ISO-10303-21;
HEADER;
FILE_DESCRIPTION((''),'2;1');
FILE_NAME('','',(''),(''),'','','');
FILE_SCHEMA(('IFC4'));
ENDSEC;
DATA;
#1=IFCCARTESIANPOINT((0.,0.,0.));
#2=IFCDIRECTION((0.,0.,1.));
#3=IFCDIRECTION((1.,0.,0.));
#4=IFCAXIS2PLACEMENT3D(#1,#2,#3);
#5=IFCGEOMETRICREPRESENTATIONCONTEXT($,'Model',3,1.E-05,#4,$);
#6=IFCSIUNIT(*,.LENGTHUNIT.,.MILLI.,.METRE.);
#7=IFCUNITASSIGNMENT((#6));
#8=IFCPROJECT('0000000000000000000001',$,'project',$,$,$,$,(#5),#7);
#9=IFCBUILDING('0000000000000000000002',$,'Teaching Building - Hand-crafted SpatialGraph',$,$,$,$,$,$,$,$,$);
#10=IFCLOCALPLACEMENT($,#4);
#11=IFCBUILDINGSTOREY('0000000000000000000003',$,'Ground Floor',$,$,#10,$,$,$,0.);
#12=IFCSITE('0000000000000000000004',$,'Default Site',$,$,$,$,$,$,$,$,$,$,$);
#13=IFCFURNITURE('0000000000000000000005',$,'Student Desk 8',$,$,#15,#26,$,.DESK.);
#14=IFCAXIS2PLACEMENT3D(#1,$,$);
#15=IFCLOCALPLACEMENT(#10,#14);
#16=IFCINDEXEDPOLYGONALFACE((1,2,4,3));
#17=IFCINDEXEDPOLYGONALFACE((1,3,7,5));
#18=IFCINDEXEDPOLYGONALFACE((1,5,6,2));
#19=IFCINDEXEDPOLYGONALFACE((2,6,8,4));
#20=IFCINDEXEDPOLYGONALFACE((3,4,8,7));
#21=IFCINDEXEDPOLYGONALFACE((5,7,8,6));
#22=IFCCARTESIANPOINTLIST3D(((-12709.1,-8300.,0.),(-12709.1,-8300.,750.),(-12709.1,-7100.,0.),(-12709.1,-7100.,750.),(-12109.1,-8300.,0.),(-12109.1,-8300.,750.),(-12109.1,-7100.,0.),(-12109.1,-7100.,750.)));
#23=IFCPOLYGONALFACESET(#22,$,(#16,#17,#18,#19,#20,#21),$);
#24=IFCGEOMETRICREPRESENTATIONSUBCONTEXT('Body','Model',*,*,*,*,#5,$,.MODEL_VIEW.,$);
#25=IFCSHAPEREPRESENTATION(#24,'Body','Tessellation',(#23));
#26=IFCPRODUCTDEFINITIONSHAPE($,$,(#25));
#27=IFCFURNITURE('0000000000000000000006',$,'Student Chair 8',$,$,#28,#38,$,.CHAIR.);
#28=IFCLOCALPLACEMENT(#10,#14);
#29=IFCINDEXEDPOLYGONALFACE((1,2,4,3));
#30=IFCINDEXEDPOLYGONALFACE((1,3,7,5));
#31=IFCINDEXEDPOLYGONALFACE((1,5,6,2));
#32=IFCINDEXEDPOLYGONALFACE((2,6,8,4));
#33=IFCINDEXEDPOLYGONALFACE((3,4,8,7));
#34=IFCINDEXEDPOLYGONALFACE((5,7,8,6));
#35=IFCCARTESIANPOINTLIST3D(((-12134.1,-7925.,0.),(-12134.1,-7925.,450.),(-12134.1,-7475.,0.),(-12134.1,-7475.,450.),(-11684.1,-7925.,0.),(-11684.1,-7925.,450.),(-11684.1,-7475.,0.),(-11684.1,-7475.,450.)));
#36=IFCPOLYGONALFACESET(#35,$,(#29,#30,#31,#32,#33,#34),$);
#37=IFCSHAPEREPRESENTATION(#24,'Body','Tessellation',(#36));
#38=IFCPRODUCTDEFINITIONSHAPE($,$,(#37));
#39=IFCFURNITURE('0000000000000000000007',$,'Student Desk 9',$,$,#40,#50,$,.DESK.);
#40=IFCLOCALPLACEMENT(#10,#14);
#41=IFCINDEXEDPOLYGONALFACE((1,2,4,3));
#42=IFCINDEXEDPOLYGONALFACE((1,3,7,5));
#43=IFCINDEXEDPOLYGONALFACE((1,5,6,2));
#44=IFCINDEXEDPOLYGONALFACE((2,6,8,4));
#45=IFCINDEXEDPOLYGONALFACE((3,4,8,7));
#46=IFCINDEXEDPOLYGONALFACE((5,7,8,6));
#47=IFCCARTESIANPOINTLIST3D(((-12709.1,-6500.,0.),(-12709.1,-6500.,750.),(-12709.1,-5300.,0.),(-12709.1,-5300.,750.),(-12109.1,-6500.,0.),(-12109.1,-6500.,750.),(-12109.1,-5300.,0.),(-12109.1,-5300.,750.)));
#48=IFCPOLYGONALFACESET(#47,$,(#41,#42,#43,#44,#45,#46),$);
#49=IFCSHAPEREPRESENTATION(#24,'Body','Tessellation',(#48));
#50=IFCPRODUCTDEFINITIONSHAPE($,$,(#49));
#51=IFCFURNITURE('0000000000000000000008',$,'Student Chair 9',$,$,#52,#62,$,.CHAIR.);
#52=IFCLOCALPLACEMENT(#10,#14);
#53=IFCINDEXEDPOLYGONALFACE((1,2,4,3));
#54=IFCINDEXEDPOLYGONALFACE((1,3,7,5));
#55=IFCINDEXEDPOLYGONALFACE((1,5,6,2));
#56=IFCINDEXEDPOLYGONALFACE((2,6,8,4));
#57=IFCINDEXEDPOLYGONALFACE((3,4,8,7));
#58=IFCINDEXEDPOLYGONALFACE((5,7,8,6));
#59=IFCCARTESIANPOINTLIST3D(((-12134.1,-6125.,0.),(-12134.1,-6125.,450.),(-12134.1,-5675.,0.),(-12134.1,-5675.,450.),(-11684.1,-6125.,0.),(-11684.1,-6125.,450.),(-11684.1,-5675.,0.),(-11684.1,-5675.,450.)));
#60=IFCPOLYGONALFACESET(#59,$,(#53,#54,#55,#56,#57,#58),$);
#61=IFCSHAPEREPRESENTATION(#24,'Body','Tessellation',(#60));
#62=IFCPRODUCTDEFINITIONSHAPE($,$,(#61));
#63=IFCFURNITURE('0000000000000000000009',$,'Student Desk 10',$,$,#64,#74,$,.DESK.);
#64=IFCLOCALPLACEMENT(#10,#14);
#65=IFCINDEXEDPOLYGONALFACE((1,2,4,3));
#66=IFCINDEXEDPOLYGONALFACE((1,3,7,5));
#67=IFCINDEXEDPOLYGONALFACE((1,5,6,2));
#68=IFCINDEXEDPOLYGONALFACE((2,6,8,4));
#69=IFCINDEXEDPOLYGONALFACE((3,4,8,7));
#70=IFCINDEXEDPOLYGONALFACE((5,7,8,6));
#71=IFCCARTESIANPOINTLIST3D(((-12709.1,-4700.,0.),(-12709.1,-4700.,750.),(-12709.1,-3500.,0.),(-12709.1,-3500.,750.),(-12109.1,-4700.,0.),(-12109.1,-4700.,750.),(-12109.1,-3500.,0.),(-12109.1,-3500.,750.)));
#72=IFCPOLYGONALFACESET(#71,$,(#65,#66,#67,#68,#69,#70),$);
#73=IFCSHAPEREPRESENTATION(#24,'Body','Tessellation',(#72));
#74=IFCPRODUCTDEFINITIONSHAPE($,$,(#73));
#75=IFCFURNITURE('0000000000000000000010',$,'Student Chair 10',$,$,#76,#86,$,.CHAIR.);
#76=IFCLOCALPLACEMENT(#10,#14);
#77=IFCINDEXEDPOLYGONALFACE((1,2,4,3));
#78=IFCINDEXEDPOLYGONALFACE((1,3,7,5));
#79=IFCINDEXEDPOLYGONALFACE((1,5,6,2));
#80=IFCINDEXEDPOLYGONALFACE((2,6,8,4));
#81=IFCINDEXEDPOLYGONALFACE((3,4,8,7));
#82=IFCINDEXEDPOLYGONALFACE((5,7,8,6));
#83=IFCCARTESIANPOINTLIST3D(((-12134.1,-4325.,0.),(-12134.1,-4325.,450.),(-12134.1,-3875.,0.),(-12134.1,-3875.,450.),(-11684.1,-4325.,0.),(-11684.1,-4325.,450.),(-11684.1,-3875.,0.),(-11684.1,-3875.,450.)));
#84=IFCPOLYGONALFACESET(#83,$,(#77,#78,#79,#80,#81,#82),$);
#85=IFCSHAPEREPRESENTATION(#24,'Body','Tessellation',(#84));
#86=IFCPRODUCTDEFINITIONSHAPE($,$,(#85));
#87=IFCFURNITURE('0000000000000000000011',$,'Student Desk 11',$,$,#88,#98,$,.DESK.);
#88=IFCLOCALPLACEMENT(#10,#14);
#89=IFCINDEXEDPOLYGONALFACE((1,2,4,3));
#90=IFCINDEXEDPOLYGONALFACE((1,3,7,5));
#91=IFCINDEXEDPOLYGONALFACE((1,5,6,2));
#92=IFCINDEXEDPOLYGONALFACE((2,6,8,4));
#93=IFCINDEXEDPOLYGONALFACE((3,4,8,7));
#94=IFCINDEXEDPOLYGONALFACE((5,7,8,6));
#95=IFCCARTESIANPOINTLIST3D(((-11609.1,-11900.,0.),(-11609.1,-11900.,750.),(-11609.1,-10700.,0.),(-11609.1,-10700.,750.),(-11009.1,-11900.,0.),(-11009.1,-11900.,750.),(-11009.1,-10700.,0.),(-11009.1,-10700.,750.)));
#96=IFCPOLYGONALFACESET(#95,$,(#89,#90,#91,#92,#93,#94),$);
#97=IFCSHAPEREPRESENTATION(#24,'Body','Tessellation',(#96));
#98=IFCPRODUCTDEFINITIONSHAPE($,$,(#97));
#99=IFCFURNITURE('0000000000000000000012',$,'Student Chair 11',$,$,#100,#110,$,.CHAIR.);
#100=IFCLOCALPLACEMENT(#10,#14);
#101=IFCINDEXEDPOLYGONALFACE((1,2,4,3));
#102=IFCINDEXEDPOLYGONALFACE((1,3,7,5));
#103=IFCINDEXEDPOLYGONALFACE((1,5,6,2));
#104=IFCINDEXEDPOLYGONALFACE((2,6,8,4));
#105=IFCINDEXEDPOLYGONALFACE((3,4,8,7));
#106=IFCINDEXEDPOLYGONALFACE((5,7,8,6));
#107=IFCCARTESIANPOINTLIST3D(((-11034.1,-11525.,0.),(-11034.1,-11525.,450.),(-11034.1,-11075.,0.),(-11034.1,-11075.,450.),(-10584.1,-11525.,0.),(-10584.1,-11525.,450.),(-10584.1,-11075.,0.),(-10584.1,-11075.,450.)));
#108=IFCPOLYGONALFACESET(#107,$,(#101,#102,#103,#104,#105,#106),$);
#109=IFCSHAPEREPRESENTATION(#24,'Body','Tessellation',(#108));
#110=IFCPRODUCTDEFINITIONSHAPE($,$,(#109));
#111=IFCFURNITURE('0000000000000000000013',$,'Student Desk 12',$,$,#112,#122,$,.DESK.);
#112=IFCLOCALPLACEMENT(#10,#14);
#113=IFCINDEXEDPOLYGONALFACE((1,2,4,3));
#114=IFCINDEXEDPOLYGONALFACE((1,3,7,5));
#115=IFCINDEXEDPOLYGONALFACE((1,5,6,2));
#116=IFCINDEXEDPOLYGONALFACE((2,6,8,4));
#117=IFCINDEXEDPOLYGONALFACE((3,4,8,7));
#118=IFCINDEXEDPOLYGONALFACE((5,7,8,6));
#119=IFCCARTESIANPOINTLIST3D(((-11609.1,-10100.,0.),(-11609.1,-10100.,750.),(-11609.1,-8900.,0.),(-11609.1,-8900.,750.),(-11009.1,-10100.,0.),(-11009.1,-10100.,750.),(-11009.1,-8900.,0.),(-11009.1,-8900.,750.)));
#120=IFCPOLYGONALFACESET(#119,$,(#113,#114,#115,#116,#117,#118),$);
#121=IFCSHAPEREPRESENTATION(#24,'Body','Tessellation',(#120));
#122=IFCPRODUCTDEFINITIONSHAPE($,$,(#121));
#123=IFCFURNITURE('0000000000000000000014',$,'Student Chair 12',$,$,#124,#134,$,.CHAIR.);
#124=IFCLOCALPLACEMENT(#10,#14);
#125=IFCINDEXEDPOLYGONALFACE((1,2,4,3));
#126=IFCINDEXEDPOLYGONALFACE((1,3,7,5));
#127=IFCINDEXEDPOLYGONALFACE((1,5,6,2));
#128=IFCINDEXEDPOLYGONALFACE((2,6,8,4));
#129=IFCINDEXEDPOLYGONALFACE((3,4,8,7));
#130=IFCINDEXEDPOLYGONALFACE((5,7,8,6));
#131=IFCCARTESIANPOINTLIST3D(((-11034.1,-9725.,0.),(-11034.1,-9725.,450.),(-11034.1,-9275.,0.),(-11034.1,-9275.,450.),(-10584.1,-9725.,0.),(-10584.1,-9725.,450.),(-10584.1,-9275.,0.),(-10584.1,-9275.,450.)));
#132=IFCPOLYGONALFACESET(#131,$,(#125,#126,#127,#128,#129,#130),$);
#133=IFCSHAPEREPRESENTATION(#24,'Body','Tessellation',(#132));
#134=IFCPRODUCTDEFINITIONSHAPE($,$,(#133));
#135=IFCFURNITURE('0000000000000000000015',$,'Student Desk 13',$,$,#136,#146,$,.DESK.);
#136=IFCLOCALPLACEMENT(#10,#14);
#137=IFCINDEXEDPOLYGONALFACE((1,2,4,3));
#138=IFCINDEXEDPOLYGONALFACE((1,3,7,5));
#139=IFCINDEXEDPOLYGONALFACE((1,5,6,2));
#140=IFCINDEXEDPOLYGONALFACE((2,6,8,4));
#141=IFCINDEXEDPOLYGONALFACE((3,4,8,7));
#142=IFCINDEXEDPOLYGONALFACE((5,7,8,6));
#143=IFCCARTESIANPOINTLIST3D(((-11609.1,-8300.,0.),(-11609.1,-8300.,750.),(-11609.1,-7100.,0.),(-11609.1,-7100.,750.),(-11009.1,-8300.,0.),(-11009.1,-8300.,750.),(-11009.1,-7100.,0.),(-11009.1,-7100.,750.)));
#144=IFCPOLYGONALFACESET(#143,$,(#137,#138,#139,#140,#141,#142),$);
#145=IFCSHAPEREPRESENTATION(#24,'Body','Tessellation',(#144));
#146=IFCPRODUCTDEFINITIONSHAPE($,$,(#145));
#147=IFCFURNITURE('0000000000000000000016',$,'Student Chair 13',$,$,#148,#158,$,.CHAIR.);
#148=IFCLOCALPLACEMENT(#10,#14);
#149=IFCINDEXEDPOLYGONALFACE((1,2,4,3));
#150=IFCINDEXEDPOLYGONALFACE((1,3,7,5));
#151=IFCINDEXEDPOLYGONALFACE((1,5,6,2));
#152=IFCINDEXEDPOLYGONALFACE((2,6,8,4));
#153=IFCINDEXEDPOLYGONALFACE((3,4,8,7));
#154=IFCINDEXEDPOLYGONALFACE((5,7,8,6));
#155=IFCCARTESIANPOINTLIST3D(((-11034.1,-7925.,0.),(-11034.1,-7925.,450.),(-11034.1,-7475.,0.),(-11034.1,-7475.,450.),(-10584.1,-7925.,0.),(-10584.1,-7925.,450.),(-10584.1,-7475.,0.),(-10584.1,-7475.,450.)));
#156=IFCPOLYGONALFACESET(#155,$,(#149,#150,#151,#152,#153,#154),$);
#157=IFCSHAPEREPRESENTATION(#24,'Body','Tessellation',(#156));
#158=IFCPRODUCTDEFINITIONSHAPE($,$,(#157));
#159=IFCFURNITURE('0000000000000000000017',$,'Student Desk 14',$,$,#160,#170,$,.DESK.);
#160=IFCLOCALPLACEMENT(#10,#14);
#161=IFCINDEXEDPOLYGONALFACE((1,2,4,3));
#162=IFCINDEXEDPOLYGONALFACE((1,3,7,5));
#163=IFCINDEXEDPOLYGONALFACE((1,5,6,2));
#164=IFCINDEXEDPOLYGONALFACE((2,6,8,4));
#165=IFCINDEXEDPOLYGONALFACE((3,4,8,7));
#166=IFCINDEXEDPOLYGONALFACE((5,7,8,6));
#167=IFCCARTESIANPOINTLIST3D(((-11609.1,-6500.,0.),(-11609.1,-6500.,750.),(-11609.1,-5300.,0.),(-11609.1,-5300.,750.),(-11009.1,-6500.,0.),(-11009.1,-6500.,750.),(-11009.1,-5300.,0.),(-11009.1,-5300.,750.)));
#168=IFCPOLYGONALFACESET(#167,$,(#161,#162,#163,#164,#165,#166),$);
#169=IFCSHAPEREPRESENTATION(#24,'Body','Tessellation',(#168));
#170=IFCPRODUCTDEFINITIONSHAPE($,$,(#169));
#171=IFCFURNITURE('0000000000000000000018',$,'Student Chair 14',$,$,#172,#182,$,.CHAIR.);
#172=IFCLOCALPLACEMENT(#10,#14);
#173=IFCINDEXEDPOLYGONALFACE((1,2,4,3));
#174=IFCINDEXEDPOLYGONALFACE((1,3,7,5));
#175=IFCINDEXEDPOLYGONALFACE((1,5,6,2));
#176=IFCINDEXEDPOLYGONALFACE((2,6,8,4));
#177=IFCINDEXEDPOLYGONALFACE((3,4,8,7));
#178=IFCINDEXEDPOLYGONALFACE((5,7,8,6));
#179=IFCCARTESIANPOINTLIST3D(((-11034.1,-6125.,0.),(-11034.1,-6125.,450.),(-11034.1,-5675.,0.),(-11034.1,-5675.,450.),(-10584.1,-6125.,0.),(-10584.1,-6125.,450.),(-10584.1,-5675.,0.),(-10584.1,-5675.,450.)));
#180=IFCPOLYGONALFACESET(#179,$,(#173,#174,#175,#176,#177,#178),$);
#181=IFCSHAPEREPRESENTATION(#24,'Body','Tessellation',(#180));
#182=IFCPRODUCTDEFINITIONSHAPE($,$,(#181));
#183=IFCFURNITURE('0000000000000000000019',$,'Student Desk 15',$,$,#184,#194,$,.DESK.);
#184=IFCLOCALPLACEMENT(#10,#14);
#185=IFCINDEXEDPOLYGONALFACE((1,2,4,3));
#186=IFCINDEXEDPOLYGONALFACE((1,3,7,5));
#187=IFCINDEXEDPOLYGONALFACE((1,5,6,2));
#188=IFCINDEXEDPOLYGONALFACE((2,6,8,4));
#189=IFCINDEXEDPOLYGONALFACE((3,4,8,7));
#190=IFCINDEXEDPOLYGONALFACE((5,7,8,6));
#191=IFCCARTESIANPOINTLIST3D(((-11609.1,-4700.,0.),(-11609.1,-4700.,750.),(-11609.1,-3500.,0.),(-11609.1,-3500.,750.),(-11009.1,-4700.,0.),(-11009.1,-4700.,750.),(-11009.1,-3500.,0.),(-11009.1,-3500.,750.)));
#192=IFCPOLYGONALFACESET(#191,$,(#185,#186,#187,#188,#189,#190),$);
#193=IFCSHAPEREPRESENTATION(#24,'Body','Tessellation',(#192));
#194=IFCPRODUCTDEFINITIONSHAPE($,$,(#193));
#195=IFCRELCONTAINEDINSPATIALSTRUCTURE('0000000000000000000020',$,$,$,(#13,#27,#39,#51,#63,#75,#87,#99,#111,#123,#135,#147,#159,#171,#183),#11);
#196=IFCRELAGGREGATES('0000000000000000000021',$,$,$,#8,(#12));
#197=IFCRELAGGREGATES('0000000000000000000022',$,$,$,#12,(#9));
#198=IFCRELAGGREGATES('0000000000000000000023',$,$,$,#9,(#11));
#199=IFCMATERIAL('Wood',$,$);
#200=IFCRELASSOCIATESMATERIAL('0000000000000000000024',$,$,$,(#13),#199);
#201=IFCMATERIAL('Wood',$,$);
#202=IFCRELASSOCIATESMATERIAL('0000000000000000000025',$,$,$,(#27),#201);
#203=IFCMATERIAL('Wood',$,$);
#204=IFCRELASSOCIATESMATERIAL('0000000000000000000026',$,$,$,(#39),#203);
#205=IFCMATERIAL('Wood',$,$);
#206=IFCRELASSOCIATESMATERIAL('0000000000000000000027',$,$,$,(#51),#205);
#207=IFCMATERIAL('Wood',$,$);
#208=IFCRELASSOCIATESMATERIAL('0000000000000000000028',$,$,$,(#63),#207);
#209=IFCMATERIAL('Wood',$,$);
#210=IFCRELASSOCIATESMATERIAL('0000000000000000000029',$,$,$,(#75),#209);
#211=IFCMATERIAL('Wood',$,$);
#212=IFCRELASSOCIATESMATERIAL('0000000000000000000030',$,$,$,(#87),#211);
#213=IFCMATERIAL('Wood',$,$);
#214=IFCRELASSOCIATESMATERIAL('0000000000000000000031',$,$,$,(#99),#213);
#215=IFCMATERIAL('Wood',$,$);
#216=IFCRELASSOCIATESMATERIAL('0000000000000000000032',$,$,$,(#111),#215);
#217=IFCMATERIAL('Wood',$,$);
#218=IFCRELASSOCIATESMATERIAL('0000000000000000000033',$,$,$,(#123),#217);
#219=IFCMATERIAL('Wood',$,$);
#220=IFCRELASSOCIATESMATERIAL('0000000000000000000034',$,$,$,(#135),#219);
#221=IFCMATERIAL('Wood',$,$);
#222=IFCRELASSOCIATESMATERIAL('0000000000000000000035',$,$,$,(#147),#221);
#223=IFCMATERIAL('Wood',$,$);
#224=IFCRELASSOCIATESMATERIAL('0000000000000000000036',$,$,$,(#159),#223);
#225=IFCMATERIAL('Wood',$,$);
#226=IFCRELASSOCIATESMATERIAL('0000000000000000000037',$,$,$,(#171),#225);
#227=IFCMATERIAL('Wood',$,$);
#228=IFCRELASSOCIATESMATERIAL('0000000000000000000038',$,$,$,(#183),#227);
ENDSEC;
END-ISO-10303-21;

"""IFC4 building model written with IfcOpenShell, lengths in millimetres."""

from ifc_helpers import new_model, si_unit, frame, origin_with_axes, origin_2d, place, context, subcontext, project, spatial, rectangle, extrude, material, element, save


model = new_model("IFC4")

# Units and contexts
model_context = context("Model", 3, precision=1e-05, world=origin_with_axes())
body_context = subcontext(model_context, "Body", "Model", "MODEL_VIEW")
ifc_project = project(units=[si_unit("LENGTHUNIT", "METRE", prefix="MILLI")], contexts=[model_context])

# Site, building, storey
site = spatial("IfcSite", under=ifc_project, Name="Default Site")
building = spatial("IfcBuilding", under=site, Name="Teaching Building - Hand-crafted SpatialGraph")
storey_placement = place(None, origin_with_axes())
storey = spatial("IfcBuildingStorey", under=building, at=storey_placement, Name="Ground Floor", Elevation=0.0)

# Furniture
ifc_material_1 = material(Name="Wood")
furniture_1_placement = place(storey_placement, frame((-12409.1, -7700.0, 0.0), z_axis=(0.0, 0.0, 1.0), x_axis=(0.0, 1.0, 0.0)))
element("IfcFurniture", 1, at=furniture_1_placement, inside=storey, material=ifc_material_1, Name="Student Desk 8", PredefinedType="DESK", context=body_context, shape_type="SweptSolid", body=[
    extrude(rectangle(XDim=1200.0, YDim=600.0, at=origin_2d()), origin_with_axes(), (0.0, 0.0, 1.0), 750.0),
])
ifc_material_2 = material(Name="Wood")
furniture_2_placement = place(storey_placement, frame((-11909.1, -7700.0, 0.0), z_axis=(0.0, 0.0, 1.0), x_axis=(1.0, 0.0, 0.0)))
element("IfcFurniture", 2, at=furniture_2_placement, inside=storey, material=ifc_material_2, Name="Student Chair 8", PredefinedType="CHAIR", context=body_context, shape_type="SweptSolid", body=[
    extrude(rectangle(XDim=450.0, YDim=450.0, at=origin_2d()), origin_with_axes(), (0.0, 0.0, 1.0), 450.0),
])
ifc_material_3 = material(Name="Wood")
furniture_3_placement = place(storey_placement, frame((-12409.1, -5900.0, 0.0), z_axis=(0.0, 0.0, 1.0), x_axis=(0.0, 1.0, 0.0)))
element("IfcFurniture", 3, at=furniture_3_placement, inside=storey, material=ifc_material_3, Name="Student Desk 9", PredefinedType="DESK", context=body_context, shape_type="SweptSolid", body=[
    extrude(rectangle(XDim=1200.0, YDim=600.0, at=origin_2d()), origin_with_axes(), (0.0, 0.0, 1.0), 750.0),
])
ifc_material_4 = material(Name="Wood")
furniture_4_placement = place(storey_placement, frame((-11909.1, -5900.0, 0.0), z_axis=(0.0, 0.0, 1.0), x_axis=(1.0, 0.0, 0.0)))
element("IfcFurniture", 4, at=furniture_4_placement, inside=storey, material=ifc_material_4, Name="Student Chair 9", PredefinedType="CHAIR", context=body_context, shape_type="SweptSolid", body=[
    extrude(rectangle(XDim=450.0, YDim=450.0, at=origin_2d()), origin_with_axes(), (0.0, 0.0, 1.0), 450.0),
])
ifc_material_5 = material(Name="Wood")
furniture_5_placement = place(storey_placement, frame((-12409.1, -4100.0, 0.0), z_axis=(0.0, 0.0, 1.0), x_axis=(0.0, 1.0, 0.0)))
element("IfcFurniture", 5, at=furniture_5_placement, inside=storey, material=ifc_material_5, Name="Student Desk 10", PredefinedType="DESK", context=body_context, shape_type="SweptSolid", body=[
    extrude(rectangle(XDim=1200.0, YDim=600.0, at=origin_2d()), origin_with_axes(), (0.0, 0.0, 1.0), 750.0),
])
ifc_material_6 = material(Name="Wood")
furniture_6_placement = place(storey_placement, frame((-11909.1, -4100.0, 0.0), z_axis=(0.0, 0.0, 1.0), x_axis=(1.0, 0.0, 0.0)))
element("IfcFurniture", 6, at=furniture_6_placement, inside=storey, material=ifc_material_6, Name="Student Chair 10", PredefinedType="CHAIR", context=body_context, shape_type="SweptSolid", body=[
    extrude(rectangle(XDim=450.0, YDim=450.0, at=origin_2d()), origin_with_axes(), (0.0, 0.0, 1.0), 450.0),
])
ifc_material_7 = material(Name="Wood")
furniture_7_placement = place(storey_placement, frame((-11309.1, -11300.0, 0.0), z_axis=(0.0, 0.0, 1.0), x_axis=(0.0, 1.0, 0.0)))
element("IfcFurniture", 7, at=furniture_7_placement, inside=storey, material=ifc_material_7, Name="Student Desk 11", PredefinedType="DESK", context=body_context, shape_type="SweptSolid", body=[
    extrude(rectangle(XDim=1200.0, YDim=600.0, at=origin_2d()), origin_with_axes(), (0.0, 0.0, 1.0), 750.0),
])
ifc_material_8 = material(Name="Wood")
furniture_8_placement = place(storey_placement, frame((-10809.1, -11300.0, 0.0), z_axis=(0.0, 0.0, 1.0), x_axis=(1.0, 0.0, 0.0)))
element("IfcFurniture", 8, at=furniture_8_placement, inside=storey, material=ifc_material_8, Name="Student Chair 11", PredefinedType="CHAIR", context=body_context, shape_type="SweptSolid", body=[
    extrude(rectangle(XDim=450.0, YDim=450.0, at=origin_2d()), origin_with_axes(), (0.0, 0.0, 1.0), 450.0),
])
ifc_material_9 = material(Name="Wood")
furniture_9_placement = place(storey_placement, frame((-11309.1, -9500.0, 0.0), z_axis=(0.0, 0.0, 1.0), x_axis=(0.0, 1.0, 0.0)))
element("IfcFurniture", 9, at=furniture_9_placement, inside=storey, material=ifc_material_9, Name="Student Desk 12", PredefinedType="DESK", context=body_context, shape_type="SweptSolid", body=[
    extrude(rectangle(XDim=1200.0, YDim=600.0, at=origin_2d()), origin_with_axes(), (0.0, 0.0, 1.0), 750.0),
])
ifc_material_10 = material(Name="Wood")
furniture_10_placement = place(storey_placement, frame((-10809.1, -9500.0, 0.0), z_axis=(0.0, 0.0, 1.0), x_axis=(1.0, 0.0, 0.0)))
element("IfcFurniture", 10, at=furniture_10_placement, inside=storey, material=ifc_material_10, Name="Student Chair 12", PredefinedType="CHAIR", context=body_context, shape_type="SweptSolid", body=[
    extrude(rectangle(XDim=450.0, YDim=450.0, at=origin_2d()), origin_with_axes(), (0.0, 0.0, 1.0), 450.0),
])
ifc_material_11 = material(Name="Wood")
furniture_11_placement = place(storey_placement, frame((-11309.1, -7700.0, 0.0), z_axis=(0.0, 0.0, 1.0), x_axis=(0.0, 1.0, 0.0)))
element("IfcFurniture", 11, at=furniture_11_placement, inside=storey, material=ifc_material_11, Name="Student Desk 13", PredefinedType="DESK", context=body_context, shape_type="SweptSolid", body=[
    extrude(rectangle(XDim=1200.0, YDim=600.0, at=origin_2d()), origin_with_axes(), (0.0, 0.0, 1.0), 750.0),
])
ifc_material_12 = material(Name="Wood")
furniture_12_placement = place(storey_placement, frame((-10809.1, -7700.0, 0.0), z_axis=(0.0, 0.0, 1.0), x_axis=(1.0, 0.0, 0.0)))
element("IfcFurniture", 12, at=furniture_12_placement, inside=storey, material=ifc_material_12, Name="Student Chair 13", PredefinedType="CHAIR", context=body_context, shape_type="SweptSolid", body=[
    extrude(rectangle(XDim=450.0, YDim=450.0, at=origin_2d()), origin_with_axes(), (0.0, 0.0, 1.0), 450.0),
])
ifc_material_13 = material(Name="Wood")
furniture_13_placement = place(storey_placement, frame((-11309.1, -5900.0, 0.0), z_axis=(0.0, 0.0, 1.0), x_axis=(0.0, 1.0, 0.0)))
element("IfcFurniture", 13, at=furniture_13_placement, inside=storey, material=ifc_material_13, Name="Student Desk 14", PredefinedType="DESK", context=body_context, shape_type="SweptSolid", body=[
    extrude(rectangle(XDim=1200.0, YDim=600.0, at=origin_2d()), origin_with_axes(), (0.0, 0.0, 1.0), 750.0),
])
ifc_material_14 = material(Name="Wood")
furniture_14_placement = place(storey_placement, frame((-10809.1, -5900.0, 0.0), z_axis=(0.0, 0.0, 1.0), x_axis=(1.0, 0.0, 0.0)))
element("IfcFurniture", 14, at=furniture_14_placement, inside=storey, material=ifc_material_14, Name="Student Chair 14", PredefinedType="CHAIR", context=body_context, shape_type="SweptSolid", body=[
    extrude(rectangle(XDim=450.0, YDim=450.0, at=origin_2d()), origin_with_axes(), (0.0, 0.0, 1.0), 450.0),
])
ifc_material_15 = material(Name="Wood")
furniture_15_placement = place(storey_placement, frame((-11309.1, -4100.0, 0.0), z_axis=(0.0, 0.0, 1.0), x_axis=(0.0, 1.0, 0.0)))
element("IfcFurniture", 15, at=furniture_15_placement, inside=storey, material=ifc_material_15, Name="Student Desk 15", PredefinedType="DESK", context=body_context, shape_type="SweptSolid", body=[
    extrude(rectangle(XDim=1200.0, YDim=600.0, at=origin_2d()), origin_with_axes(), (0.0, 0.0, 1.0), 750.0),
])

save(model, "model.ifc")
